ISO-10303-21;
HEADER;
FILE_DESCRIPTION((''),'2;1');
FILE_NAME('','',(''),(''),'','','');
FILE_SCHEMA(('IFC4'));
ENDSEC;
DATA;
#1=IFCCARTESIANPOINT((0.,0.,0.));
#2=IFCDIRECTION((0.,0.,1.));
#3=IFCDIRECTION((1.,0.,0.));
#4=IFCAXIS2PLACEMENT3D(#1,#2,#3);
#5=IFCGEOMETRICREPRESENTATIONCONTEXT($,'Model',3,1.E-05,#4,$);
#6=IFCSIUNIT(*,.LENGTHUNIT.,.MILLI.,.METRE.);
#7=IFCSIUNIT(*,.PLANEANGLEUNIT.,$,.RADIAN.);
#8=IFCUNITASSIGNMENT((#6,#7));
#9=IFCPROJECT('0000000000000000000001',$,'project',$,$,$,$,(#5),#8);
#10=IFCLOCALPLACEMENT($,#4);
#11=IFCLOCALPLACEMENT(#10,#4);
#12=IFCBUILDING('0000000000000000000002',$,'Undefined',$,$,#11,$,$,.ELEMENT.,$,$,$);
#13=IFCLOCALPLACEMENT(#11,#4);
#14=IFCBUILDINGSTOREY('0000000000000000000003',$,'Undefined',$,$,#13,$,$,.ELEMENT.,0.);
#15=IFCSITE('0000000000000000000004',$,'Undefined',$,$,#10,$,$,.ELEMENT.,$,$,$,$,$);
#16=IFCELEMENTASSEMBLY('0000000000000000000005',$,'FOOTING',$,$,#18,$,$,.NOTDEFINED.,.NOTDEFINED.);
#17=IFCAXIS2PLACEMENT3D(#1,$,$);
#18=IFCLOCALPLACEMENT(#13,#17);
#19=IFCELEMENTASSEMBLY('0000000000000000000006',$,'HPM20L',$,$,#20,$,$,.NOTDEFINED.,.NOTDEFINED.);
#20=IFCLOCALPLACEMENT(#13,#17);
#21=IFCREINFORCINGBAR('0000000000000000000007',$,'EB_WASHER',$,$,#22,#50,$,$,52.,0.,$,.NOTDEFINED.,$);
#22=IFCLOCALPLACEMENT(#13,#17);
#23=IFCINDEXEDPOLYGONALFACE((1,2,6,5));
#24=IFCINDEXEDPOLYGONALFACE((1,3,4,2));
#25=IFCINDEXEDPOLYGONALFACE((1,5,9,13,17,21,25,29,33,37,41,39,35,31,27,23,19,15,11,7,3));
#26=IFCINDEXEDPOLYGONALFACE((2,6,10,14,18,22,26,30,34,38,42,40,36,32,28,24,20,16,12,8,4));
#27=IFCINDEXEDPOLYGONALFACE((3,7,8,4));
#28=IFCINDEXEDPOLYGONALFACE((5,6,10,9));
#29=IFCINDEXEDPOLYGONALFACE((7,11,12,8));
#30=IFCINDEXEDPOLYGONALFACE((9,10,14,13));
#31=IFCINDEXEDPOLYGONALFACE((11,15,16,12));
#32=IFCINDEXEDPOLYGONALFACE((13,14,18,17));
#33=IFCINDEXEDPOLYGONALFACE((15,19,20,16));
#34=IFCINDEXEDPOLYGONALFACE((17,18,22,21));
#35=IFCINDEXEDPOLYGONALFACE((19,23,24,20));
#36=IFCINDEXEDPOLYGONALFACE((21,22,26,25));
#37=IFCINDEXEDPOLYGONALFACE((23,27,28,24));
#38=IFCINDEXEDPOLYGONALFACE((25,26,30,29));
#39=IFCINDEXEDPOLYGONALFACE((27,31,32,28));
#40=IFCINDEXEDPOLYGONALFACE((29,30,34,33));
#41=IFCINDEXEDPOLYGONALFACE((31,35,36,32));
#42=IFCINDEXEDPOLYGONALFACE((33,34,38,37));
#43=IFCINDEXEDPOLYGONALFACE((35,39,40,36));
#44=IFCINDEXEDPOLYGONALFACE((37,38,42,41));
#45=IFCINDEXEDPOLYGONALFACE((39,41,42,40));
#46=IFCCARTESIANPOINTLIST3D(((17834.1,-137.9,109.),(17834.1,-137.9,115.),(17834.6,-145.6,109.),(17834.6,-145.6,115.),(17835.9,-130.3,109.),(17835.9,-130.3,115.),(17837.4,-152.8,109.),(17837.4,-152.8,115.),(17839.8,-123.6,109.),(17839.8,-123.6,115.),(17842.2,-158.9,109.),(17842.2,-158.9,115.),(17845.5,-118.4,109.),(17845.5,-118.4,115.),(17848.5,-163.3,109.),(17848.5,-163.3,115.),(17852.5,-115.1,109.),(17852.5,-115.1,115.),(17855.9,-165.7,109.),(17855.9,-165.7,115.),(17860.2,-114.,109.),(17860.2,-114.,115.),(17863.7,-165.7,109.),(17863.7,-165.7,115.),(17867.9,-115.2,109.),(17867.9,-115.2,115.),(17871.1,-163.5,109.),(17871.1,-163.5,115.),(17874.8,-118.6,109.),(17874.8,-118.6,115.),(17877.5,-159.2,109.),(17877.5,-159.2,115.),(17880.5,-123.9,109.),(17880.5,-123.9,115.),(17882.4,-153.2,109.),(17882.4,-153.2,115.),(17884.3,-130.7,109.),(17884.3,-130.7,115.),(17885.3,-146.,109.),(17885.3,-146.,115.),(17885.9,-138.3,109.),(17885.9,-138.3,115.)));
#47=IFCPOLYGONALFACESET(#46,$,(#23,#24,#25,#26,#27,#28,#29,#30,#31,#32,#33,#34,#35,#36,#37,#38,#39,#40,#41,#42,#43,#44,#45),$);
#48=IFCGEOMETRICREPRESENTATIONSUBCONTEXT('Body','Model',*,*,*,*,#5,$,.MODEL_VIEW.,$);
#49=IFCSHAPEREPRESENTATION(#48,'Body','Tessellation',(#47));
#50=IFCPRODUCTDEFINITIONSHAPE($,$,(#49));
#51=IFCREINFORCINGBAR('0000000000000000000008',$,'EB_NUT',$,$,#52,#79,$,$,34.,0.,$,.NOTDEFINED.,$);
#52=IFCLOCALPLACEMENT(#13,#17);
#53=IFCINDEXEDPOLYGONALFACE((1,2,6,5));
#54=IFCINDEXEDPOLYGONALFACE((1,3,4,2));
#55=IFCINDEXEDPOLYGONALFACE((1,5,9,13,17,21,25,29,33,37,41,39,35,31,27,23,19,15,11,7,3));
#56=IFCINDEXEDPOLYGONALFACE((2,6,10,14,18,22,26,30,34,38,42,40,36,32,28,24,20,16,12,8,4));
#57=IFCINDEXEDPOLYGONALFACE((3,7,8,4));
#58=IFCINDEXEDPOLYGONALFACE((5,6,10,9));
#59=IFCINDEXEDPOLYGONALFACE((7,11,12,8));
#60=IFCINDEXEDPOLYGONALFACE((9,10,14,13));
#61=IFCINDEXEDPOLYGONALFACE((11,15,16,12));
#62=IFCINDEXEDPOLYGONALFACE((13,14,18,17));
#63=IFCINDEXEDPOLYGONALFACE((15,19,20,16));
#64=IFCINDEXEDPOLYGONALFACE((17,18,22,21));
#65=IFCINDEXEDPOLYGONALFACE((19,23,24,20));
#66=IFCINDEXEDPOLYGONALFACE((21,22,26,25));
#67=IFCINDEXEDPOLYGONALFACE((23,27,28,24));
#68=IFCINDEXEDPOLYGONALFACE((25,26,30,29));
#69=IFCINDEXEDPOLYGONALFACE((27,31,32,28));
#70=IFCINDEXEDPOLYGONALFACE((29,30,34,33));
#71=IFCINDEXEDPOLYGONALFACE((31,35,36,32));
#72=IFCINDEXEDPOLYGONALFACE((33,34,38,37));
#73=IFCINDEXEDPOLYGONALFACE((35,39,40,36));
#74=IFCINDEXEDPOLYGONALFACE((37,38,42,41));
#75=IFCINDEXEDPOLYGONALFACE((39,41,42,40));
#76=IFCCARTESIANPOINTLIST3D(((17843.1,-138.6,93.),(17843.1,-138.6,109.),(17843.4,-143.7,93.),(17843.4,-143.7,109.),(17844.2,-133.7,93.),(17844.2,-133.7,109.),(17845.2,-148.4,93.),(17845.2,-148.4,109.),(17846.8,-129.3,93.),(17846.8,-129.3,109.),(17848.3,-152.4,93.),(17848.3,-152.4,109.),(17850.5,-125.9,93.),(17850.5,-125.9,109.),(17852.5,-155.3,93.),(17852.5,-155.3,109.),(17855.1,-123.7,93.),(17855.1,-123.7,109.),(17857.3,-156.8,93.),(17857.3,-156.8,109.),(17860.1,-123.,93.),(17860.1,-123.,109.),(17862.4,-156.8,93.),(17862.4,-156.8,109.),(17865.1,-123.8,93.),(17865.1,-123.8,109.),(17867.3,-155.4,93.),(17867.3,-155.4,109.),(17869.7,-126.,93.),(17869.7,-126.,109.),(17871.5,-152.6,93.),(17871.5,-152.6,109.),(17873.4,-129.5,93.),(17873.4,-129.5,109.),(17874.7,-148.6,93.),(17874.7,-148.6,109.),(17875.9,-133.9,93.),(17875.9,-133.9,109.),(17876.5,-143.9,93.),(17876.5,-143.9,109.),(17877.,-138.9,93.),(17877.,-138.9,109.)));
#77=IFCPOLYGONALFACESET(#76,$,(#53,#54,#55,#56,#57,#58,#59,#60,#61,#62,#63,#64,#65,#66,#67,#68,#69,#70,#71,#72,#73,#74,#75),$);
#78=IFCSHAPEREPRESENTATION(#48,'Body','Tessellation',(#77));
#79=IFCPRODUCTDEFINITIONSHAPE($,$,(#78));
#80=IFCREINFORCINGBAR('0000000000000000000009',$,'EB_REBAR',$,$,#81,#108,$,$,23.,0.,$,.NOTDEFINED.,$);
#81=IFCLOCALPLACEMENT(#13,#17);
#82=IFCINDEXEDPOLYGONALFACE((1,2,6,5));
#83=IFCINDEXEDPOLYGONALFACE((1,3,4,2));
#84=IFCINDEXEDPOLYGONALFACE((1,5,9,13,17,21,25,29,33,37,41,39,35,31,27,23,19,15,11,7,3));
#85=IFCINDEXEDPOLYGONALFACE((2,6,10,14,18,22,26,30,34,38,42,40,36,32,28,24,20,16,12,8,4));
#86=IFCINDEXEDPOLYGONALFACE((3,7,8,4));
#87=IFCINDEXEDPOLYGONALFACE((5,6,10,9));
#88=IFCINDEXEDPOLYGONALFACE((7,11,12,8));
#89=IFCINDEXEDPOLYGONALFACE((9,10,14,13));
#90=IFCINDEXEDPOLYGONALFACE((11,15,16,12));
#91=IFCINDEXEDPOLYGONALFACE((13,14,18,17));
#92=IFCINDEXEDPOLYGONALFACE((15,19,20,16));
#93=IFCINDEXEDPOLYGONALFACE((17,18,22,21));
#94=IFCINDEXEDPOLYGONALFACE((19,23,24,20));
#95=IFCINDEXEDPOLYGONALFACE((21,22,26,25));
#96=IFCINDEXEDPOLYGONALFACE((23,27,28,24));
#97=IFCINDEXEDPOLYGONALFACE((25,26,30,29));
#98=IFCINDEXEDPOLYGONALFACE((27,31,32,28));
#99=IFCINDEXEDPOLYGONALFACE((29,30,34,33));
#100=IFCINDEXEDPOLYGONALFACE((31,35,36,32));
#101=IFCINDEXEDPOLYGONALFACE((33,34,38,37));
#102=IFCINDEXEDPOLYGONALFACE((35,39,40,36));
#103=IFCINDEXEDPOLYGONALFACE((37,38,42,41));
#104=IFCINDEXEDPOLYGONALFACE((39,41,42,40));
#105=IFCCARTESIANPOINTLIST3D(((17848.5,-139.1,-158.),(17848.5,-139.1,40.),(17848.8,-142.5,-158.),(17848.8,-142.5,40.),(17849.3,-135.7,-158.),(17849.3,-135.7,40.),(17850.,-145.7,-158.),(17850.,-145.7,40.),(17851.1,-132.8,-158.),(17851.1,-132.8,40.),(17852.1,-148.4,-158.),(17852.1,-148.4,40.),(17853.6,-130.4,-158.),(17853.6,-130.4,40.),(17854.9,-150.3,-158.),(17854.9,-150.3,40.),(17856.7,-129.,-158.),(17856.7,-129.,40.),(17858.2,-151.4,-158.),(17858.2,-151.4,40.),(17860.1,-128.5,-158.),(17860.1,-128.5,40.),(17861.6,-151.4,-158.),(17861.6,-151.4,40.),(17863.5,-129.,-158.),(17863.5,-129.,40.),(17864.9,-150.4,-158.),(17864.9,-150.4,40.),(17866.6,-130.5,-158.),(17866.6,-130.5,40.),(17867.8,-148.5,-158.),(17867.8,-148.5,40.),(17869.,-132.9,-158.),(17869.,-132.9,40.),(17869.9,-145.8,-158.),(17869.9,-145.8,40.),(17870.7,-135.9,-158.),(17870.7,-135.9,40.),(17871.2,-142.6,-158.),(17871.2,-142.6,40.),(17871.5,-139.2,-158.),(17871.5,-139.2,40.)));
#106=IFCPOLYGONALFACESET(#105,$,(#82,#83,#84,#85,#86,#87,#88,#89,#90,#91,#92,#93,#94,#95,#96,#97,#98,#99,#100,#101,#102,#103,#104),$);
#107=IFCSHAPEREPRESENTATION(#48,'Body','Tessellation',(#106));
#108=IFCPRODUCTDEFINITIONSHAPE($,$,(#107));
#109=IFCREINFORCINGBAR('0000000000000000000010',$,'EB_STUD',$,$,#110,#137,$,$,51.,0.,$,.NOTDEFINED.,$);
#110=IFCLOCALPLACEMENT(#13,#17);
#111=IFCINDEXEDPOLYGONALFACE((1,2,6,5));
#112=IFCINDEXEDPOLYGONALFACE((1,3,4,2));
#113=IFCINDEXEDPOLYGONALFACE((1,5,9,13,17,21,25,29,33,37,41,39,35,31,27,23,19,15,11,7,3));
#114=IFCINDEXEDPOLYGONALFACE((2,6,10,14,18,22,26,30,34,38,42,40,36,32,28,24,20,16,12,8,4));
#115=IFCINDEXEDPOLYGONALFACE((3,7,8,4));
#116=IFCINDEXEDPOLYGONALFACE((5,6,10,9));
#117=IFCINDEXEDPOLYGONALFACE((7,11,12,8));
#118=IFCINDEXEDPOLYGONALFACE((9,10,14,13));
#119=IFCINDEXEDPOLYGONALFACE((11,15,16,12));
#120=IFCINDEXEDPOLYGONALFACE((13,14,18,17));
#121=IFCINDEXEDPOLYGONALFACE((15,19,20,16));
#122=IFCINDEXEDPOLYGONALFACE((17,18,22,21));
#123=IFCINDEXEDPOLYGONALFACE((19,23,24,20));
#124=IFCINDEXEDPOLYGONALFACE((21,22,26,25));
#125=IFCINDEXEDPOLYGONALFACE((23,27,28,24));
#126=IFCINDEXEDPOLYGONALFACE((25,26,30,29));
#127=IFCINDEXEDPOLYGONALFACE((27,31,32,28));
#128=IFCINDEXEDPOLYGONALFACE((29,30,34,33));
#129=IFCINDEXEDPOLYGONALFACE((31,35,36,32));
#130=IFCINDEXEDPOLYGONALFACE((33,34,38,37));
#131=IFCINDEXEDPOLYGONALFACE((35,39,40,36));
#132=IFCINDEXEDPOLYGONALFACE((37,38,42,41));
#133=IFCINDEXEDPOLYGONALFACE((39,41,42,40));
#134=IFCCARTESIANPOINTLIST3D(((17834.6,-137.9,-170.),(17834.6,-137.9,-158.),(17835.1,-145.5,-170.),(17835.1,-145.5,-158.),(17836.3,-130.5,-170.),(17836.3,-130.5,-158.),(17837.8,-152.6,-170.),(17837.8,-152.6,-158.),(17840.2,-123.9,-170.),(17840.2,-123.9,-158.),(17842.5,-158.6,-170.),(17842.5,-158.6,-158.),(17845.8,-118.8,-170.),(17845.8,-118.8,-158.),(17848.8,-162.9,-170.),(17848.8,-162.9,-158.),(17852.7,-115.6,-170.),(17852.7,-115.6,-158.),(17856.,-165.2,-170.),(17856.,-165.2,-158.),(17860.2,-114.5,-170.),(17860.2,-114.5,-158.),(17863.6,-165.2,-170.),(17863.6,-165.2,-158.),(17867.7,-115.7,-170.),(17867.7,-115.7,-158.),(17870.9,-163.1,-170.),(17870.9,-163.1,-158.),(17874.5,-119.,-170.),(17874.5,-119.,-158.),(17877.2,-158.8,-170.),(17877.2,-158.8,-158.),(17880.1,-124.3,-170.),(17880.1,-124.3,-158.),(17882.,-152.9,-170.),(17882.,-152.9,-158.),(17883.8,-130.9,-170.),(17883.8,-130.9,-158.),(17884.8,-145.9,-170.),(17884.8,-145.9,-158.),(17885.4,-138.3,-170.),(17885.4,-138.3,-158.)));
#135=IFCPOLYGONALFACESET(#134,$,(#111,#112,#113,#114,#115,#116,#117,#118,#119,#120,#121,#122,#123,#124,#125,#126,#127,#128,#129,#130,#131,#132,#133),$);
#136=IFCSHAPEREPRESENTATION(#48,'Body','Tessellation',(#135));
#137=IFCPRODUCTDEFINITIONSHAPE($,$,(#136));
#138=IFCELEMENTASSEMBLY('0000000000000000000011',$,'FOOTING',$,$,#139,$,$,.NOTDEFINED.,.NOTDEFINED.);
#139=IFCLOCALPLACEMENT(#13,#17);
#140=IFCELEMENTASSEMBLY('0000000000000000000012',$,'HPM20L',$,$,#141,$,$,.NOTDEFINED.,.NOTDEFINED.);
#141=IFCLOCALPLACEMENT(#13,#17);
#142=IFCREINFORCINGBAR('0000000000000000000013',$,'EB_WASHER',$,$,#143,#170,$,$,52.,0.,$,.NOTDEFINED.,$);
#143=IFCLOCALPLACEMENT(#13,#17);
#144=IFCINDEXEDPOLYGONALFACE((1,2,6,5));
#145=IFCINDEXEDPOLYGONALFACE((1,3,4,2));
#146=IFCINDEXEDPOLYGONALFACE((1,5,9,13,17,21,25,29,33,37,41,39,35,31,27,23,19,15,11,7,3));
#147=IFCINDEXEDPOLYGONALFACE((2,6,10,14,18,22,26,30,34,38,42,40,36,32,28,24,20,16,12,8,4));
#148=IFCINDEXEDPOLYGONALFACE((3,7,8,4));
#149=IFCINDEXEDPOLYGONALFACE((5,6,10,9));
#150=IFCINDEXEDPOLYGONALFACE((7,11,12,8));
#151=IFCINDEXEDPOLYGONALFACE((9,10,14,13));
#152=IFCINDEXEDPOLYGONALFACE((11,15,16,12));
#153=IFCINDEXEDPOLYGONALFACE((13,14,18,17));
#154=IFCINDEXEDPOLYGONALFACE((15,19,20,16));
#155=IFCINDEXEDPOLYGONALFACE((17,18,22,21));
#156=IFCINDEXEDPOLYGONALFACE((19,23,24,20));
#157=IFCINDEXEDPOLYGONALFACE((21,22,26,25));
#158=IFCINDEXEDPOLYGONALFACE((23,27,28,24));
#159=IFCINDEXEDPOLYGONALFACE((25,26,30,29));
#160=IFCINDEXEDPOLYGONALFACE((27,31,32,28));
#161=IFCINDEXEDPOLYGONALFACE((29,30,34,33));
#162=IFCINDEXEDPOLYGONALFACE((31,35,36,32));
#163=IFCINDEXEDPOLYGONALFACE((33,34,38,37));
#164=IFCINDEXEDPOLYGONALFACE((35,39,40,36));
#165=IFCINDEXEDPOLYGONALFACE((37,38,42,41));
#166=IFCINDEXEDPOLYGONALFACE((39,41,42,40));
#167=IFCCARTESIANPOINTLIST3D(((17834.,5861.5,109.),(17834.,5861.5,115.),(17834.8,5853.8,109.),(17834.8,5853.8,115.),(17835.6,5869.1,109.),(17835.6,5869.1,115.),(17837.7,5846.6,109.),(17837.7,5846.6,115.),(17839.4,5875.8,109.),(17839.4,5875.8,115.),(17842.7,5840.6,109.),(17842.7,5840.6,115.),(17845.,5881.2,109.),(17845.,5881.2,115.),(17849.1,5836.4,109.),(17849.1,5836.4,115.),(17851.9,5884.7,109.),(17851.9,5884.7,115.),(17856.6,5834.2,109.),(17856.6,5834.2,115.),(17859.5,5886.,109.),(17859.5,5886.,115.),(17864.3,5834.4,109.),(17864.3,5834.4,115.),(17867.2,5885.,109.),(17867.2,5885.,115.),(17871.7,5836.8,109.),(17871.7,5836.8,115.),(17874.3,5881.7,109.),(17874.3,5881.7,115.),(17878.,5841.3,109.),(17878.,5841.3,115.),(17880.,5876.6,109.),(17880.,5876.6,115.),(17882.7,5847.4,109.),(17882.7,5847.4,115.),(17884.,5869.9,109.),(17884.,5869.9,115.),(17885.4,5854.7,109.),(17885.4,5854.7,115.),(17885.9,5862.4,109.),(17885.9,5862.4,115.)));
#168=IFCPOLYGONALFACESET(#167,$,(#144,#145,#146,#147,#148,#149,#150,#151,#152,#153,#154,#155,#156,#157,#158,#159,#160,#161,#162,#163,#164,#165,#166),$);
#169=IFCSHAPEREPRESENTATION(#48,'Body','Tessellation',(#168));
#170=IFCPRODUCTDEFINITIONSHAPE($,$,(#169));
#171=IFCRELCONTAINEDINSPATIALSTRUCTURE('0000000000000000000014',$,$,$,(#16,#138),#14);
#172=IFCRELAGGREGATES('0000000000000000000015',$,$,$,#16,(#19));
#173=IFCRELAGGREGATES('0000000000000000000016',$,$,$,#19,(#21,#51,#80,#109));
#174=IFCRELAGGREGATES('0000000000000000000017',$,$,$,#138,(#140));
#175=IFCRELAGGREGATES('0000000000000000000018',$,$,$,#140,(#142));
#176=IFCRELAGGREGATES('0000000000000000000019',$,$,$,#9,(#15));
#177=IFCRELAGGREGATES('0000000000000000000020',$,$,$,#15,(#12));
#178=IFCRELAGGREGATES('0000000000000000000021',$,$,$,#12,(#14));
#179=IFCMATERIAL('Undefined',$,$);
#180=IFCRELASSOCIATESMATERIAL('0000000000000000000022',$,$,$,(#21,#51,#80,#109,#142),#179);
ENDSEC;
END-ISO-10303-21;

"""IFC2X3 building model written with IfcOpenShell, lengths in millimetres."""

from ifc_helpers import new_model, entity, si_unit, frame, origin_with_axes, place, context, subcontext, project, spatial, source, transform, mapped, material, element, aggregate, save


model = new_model("IFC2X3")

# Units and contexts
model_context = context("Model", 3, precision=1e-05, world=origin_with_axes())
body_context = subcontext(model_context, "Body", "Model", "MODEL_VIEW")
ifc_project = project(units=[si_unit("LENGTHUNIT", "METRE", prefix="MILLI"), si_unit("PLANEANGLEUNIT", "RADIAN")], contexts=[model_context])

# Site, building, storey
site_placement = place(None, origin_with_axes())
site = spatial("IfcSite", under=ifc_project, at=site_placement, Name="Undefined", CompositionType="ELEMENT")
building_placement = place(site_placement, origin_with_axes())
building = spatial("IfcBuilding", under=site, at=building_placement, Name="Undefined", CompositionType="ELEMENT")
storey_placement = place(building_placement, origin_with_axes())
storey = spatial("IfcBuildingStorey", under=building, at=storey_placement, Name="Undefined", CompositionType="ELEMENT", Elevation=0.0)

# Shared definitions
ifc_material_1 = material(Name="Undefined")

# Element assemblies, reinforcing bars
assembly_1_placement = place(storey_placement, origin_with_axes())
assembly_1 = element("IfcElementAssembly", 1, at=assembly_1_placement, inside=storey, Name="FOOTING", AssemblyPlace="NOTDEFINED", PredefinedType="NOTDEFINED")
assembly_2_placement = place(assembly_1_placement, origin_with_axes())
assembly_2 = element("IfcElementAssembly", 2, at=assembly_2_placement, Name="HPM20L", AssemblyPlace="NOTDEFINED", PredefinedType="NOTDEFINED")
aggregate(assembly_1, [assembly_2])
shared_shape_1 = source(origin_with_axes(), body_context, "Body", "AdvancedSweptSolid", [
    entity("IfcSweptDiskSolid", entity("IfcTrimmedCurve", entity("IfcLine", entity("IfcCartesianPoint", [0.0, 0.0, 0.0]), entity("IfcVector", entity("IfcDirection", [1.0, 0.0, 0.0]), 1.0)), [entity("IfcParameterValue", 0.0)], [entity("IfcParameterValue", 6.0)], True, "PARAMETER"), 26.0, None, 0.0, 6.0),
])
reinforcing_bar_1_placement = place(assembly_2_placement, frame((17860.0, -140.0, 115.0), z_axis=(0.007839, 0.999969, 0.0), x_axis=(0.0, 0.0, -1.0)))
reinforcing_bar_1 = element("IfcReinforcingBar", 3, at=reinforcing_bar_1_placement, material=ifc_material_1, Name="EB_WASHER", BarRole="NOTDEFINED", CrossSectionArea=0.0, NominalDiameter=52.0, context=body_context, shape_type="MappedRepresentation", body=[
    mapped(shared_shape_1, transform((0.0, 0.0, 0.0))),
])
shared_shape_2 = source(origin_with_axes(), body_context, "Body", "AdvancedSweptSolid", [
    entity("IfcSweptDiskSolid", entity("IfcTrimmedCurve", entity("IfcLine", entity("IfcCartesianPoint", [0.0, 0.0, 0.0]), entity("IfcVector", entity("IfcDirection", [1.0, 0.0, 0.0]), 1.0)), [entity("IfcParameterValue", 0.0)], [entity("IfcParameterValue", 16.0)], True, "PARAMETER"), 17.0, None, 0.0, 16.0),
])
reinforcing_bar_2_placement = place(assembly_2_placement, frame((17860.0, -140.0, 109.0), z_axis=(0.007839, 0.999969, 0.0), x_axis=(0.0, 0.0, -1.0)))
reinforcing_bar_2 = element("IfcReinforcingBar", 4, at=reinforcing_bar_2_placement, material=ifc_material_1, Name="EB_NUT", BarRole="NOTDEFINED", CrossSectionArea=0.0, NominalDiameter=34.0, context=body_context, shape_type="MappedRepresentation", body=[
    mapped(shared_shape_2, transform((0.0, 0.0, 0.0))),
])
shared_shape_3 = source(origin_with_axes(), body_context, "Body", "AdvancedSweptSolid", [
    entity("IfcSweptDiskSolid", entity("IfcTrimmedCurve", entity("IfcLine", entity("IfcCartesianPoint", [0.0, 0.0, 0.0]), entity("IfcVector", entity("IfcDirection", [1.0, 0.0, 0.0]), 1.0)), [entity("IfcParameterValue", 0.0)], [entity("IfcParameterValue", 198.0)], True, "PARAMETER"), 11.5, None, 0.0, 198.0),
])
reinforcing_bar_3_placement = place(assembly_2_placement, frame((17860.0, -140.0, 40.0), z_axis=(0.007839, 0.999969, 0.0), x_axis=(0.0, 0.0, -1.0)))
reinforcing_bar_3 = element("IfcReinforcingBar", 5, at=reinforcing_bar_3_placement, material=ifc_material_1, Name="EB_REBAR", BarRole="NOTDEFINED", CrossSectionArea=0.0, NominalDiameter=23.0, context=body_context, shape_type="MappedRepresentation", body=[
    mapped(shared_shape_3, transform((0.0, 0.0, 0.0))),
])
shared_shape_4 = source(origin_with_axes(), body_context, "Body", "AdvancedSweptSolid", [
    entity("IfcSweptDiskSolid", entity("IfcTrimmedCurve", entity("IfcLine", entity("IfcCartesianPoint", [0.0, 0.0, 0.0]), entity("IfcVector", entity("IfcDirection", [1.0, 0.0, 0.0]), 1.0)), [entity("IfcParameterValue", 0.0)], [entity("IfcParameterValue", 12.0)], True, "PARAMETER"), 25.5, None, 0.0, 12.0),
])
reinforcing_bar_4_placement = place(assembly_2_placement, frame((17860.0, -140.0, -158.0), z_axis=(0.007839, 0.999969, 0.0), x_axis=(0.0, 0.0, -1.0)))
reinforcing_bar_4 = element("IfcReinforcingBar", 6, at=reinforcing_bar_4_placement, material=ifc_material_1, Name="EB_STUD", BarRole="NOTDEFINED", CrossSectionArea=0.0, NominalDiameter=51.0, context=body_context, shape_type="MappedRepresentation", body=[
    mapped(shared_shape_4, transform((0.0, 0.0, 0.0))),
])
aggregate(assembly_2, [reinforcing_bar_1, reinforcing_bar_2, reinforcing_bar_3, reinforcing_bar_4])
assembly_3_placement = place(storey_placement, origin_with_axes())
assembly_3 = element("IfcElementAssembly", 7, at=assembly_3_placement, inside=storey, Name="FOOTING", AssemblyPlace="NOTDEFINED", PredefinedType="NOTDEFINED")
assembly_4_placement = place(assembly_3_placement, origin_with_axes())
assembly_4 = element("IfcElementAssembly", 8, at=assembly_4_placement, Name="HPM20L", AssemblyPlace="NOTDEFINED", PredefinedType="NOTDEFINED")
aggregate(assembly_3, [assembly_4])
shared_shape_5 = source(origin_with_axes(), body_context, "Body", "AdvancedSweptSolid", [
    entity("IfcSweptDiskSolid", entity("IfcTrimmedCurve", entity("IfcLine", entity("IfcCartesianPoint", [0.0, 0.0, 0.0]), entity("IfcVector", entity("IfcDirection", [1.0, 0.0, 0.0]), 1.0)), [entity("IfcParameterValue", 0.0)], [entity("IfcParameterValue", 6.0)], True, "PARAMETER"), 26.0, None, 0.0, 6.0),
])
reinforcing_bar_5_placement = place(assembly_4_placement, frame((17860.0, 5860.0, 115.0), z_axis=(-0.311755, 0.950162, 0.0), x_axis=(0.0, 0.0, -1.0)))
reinforcing_bar_5 = element("IfcReinforcingBar", 9, at=reinforcing_bar_5_placement, material=ifc_material_1, Name="EB_WASHER", BarRole="NOTDEFINED", CrossSectionArea=0.0, NominalDiameter=52.0, context=body_context, shape_type="MappedRepresentation", body=[
    mapped(shared_shape_5, transform((0.0, 0.0, 0.0))),
])
aggregate(assembly_4, [reinforcing_bar_5])

save(model, "model.ifc")
